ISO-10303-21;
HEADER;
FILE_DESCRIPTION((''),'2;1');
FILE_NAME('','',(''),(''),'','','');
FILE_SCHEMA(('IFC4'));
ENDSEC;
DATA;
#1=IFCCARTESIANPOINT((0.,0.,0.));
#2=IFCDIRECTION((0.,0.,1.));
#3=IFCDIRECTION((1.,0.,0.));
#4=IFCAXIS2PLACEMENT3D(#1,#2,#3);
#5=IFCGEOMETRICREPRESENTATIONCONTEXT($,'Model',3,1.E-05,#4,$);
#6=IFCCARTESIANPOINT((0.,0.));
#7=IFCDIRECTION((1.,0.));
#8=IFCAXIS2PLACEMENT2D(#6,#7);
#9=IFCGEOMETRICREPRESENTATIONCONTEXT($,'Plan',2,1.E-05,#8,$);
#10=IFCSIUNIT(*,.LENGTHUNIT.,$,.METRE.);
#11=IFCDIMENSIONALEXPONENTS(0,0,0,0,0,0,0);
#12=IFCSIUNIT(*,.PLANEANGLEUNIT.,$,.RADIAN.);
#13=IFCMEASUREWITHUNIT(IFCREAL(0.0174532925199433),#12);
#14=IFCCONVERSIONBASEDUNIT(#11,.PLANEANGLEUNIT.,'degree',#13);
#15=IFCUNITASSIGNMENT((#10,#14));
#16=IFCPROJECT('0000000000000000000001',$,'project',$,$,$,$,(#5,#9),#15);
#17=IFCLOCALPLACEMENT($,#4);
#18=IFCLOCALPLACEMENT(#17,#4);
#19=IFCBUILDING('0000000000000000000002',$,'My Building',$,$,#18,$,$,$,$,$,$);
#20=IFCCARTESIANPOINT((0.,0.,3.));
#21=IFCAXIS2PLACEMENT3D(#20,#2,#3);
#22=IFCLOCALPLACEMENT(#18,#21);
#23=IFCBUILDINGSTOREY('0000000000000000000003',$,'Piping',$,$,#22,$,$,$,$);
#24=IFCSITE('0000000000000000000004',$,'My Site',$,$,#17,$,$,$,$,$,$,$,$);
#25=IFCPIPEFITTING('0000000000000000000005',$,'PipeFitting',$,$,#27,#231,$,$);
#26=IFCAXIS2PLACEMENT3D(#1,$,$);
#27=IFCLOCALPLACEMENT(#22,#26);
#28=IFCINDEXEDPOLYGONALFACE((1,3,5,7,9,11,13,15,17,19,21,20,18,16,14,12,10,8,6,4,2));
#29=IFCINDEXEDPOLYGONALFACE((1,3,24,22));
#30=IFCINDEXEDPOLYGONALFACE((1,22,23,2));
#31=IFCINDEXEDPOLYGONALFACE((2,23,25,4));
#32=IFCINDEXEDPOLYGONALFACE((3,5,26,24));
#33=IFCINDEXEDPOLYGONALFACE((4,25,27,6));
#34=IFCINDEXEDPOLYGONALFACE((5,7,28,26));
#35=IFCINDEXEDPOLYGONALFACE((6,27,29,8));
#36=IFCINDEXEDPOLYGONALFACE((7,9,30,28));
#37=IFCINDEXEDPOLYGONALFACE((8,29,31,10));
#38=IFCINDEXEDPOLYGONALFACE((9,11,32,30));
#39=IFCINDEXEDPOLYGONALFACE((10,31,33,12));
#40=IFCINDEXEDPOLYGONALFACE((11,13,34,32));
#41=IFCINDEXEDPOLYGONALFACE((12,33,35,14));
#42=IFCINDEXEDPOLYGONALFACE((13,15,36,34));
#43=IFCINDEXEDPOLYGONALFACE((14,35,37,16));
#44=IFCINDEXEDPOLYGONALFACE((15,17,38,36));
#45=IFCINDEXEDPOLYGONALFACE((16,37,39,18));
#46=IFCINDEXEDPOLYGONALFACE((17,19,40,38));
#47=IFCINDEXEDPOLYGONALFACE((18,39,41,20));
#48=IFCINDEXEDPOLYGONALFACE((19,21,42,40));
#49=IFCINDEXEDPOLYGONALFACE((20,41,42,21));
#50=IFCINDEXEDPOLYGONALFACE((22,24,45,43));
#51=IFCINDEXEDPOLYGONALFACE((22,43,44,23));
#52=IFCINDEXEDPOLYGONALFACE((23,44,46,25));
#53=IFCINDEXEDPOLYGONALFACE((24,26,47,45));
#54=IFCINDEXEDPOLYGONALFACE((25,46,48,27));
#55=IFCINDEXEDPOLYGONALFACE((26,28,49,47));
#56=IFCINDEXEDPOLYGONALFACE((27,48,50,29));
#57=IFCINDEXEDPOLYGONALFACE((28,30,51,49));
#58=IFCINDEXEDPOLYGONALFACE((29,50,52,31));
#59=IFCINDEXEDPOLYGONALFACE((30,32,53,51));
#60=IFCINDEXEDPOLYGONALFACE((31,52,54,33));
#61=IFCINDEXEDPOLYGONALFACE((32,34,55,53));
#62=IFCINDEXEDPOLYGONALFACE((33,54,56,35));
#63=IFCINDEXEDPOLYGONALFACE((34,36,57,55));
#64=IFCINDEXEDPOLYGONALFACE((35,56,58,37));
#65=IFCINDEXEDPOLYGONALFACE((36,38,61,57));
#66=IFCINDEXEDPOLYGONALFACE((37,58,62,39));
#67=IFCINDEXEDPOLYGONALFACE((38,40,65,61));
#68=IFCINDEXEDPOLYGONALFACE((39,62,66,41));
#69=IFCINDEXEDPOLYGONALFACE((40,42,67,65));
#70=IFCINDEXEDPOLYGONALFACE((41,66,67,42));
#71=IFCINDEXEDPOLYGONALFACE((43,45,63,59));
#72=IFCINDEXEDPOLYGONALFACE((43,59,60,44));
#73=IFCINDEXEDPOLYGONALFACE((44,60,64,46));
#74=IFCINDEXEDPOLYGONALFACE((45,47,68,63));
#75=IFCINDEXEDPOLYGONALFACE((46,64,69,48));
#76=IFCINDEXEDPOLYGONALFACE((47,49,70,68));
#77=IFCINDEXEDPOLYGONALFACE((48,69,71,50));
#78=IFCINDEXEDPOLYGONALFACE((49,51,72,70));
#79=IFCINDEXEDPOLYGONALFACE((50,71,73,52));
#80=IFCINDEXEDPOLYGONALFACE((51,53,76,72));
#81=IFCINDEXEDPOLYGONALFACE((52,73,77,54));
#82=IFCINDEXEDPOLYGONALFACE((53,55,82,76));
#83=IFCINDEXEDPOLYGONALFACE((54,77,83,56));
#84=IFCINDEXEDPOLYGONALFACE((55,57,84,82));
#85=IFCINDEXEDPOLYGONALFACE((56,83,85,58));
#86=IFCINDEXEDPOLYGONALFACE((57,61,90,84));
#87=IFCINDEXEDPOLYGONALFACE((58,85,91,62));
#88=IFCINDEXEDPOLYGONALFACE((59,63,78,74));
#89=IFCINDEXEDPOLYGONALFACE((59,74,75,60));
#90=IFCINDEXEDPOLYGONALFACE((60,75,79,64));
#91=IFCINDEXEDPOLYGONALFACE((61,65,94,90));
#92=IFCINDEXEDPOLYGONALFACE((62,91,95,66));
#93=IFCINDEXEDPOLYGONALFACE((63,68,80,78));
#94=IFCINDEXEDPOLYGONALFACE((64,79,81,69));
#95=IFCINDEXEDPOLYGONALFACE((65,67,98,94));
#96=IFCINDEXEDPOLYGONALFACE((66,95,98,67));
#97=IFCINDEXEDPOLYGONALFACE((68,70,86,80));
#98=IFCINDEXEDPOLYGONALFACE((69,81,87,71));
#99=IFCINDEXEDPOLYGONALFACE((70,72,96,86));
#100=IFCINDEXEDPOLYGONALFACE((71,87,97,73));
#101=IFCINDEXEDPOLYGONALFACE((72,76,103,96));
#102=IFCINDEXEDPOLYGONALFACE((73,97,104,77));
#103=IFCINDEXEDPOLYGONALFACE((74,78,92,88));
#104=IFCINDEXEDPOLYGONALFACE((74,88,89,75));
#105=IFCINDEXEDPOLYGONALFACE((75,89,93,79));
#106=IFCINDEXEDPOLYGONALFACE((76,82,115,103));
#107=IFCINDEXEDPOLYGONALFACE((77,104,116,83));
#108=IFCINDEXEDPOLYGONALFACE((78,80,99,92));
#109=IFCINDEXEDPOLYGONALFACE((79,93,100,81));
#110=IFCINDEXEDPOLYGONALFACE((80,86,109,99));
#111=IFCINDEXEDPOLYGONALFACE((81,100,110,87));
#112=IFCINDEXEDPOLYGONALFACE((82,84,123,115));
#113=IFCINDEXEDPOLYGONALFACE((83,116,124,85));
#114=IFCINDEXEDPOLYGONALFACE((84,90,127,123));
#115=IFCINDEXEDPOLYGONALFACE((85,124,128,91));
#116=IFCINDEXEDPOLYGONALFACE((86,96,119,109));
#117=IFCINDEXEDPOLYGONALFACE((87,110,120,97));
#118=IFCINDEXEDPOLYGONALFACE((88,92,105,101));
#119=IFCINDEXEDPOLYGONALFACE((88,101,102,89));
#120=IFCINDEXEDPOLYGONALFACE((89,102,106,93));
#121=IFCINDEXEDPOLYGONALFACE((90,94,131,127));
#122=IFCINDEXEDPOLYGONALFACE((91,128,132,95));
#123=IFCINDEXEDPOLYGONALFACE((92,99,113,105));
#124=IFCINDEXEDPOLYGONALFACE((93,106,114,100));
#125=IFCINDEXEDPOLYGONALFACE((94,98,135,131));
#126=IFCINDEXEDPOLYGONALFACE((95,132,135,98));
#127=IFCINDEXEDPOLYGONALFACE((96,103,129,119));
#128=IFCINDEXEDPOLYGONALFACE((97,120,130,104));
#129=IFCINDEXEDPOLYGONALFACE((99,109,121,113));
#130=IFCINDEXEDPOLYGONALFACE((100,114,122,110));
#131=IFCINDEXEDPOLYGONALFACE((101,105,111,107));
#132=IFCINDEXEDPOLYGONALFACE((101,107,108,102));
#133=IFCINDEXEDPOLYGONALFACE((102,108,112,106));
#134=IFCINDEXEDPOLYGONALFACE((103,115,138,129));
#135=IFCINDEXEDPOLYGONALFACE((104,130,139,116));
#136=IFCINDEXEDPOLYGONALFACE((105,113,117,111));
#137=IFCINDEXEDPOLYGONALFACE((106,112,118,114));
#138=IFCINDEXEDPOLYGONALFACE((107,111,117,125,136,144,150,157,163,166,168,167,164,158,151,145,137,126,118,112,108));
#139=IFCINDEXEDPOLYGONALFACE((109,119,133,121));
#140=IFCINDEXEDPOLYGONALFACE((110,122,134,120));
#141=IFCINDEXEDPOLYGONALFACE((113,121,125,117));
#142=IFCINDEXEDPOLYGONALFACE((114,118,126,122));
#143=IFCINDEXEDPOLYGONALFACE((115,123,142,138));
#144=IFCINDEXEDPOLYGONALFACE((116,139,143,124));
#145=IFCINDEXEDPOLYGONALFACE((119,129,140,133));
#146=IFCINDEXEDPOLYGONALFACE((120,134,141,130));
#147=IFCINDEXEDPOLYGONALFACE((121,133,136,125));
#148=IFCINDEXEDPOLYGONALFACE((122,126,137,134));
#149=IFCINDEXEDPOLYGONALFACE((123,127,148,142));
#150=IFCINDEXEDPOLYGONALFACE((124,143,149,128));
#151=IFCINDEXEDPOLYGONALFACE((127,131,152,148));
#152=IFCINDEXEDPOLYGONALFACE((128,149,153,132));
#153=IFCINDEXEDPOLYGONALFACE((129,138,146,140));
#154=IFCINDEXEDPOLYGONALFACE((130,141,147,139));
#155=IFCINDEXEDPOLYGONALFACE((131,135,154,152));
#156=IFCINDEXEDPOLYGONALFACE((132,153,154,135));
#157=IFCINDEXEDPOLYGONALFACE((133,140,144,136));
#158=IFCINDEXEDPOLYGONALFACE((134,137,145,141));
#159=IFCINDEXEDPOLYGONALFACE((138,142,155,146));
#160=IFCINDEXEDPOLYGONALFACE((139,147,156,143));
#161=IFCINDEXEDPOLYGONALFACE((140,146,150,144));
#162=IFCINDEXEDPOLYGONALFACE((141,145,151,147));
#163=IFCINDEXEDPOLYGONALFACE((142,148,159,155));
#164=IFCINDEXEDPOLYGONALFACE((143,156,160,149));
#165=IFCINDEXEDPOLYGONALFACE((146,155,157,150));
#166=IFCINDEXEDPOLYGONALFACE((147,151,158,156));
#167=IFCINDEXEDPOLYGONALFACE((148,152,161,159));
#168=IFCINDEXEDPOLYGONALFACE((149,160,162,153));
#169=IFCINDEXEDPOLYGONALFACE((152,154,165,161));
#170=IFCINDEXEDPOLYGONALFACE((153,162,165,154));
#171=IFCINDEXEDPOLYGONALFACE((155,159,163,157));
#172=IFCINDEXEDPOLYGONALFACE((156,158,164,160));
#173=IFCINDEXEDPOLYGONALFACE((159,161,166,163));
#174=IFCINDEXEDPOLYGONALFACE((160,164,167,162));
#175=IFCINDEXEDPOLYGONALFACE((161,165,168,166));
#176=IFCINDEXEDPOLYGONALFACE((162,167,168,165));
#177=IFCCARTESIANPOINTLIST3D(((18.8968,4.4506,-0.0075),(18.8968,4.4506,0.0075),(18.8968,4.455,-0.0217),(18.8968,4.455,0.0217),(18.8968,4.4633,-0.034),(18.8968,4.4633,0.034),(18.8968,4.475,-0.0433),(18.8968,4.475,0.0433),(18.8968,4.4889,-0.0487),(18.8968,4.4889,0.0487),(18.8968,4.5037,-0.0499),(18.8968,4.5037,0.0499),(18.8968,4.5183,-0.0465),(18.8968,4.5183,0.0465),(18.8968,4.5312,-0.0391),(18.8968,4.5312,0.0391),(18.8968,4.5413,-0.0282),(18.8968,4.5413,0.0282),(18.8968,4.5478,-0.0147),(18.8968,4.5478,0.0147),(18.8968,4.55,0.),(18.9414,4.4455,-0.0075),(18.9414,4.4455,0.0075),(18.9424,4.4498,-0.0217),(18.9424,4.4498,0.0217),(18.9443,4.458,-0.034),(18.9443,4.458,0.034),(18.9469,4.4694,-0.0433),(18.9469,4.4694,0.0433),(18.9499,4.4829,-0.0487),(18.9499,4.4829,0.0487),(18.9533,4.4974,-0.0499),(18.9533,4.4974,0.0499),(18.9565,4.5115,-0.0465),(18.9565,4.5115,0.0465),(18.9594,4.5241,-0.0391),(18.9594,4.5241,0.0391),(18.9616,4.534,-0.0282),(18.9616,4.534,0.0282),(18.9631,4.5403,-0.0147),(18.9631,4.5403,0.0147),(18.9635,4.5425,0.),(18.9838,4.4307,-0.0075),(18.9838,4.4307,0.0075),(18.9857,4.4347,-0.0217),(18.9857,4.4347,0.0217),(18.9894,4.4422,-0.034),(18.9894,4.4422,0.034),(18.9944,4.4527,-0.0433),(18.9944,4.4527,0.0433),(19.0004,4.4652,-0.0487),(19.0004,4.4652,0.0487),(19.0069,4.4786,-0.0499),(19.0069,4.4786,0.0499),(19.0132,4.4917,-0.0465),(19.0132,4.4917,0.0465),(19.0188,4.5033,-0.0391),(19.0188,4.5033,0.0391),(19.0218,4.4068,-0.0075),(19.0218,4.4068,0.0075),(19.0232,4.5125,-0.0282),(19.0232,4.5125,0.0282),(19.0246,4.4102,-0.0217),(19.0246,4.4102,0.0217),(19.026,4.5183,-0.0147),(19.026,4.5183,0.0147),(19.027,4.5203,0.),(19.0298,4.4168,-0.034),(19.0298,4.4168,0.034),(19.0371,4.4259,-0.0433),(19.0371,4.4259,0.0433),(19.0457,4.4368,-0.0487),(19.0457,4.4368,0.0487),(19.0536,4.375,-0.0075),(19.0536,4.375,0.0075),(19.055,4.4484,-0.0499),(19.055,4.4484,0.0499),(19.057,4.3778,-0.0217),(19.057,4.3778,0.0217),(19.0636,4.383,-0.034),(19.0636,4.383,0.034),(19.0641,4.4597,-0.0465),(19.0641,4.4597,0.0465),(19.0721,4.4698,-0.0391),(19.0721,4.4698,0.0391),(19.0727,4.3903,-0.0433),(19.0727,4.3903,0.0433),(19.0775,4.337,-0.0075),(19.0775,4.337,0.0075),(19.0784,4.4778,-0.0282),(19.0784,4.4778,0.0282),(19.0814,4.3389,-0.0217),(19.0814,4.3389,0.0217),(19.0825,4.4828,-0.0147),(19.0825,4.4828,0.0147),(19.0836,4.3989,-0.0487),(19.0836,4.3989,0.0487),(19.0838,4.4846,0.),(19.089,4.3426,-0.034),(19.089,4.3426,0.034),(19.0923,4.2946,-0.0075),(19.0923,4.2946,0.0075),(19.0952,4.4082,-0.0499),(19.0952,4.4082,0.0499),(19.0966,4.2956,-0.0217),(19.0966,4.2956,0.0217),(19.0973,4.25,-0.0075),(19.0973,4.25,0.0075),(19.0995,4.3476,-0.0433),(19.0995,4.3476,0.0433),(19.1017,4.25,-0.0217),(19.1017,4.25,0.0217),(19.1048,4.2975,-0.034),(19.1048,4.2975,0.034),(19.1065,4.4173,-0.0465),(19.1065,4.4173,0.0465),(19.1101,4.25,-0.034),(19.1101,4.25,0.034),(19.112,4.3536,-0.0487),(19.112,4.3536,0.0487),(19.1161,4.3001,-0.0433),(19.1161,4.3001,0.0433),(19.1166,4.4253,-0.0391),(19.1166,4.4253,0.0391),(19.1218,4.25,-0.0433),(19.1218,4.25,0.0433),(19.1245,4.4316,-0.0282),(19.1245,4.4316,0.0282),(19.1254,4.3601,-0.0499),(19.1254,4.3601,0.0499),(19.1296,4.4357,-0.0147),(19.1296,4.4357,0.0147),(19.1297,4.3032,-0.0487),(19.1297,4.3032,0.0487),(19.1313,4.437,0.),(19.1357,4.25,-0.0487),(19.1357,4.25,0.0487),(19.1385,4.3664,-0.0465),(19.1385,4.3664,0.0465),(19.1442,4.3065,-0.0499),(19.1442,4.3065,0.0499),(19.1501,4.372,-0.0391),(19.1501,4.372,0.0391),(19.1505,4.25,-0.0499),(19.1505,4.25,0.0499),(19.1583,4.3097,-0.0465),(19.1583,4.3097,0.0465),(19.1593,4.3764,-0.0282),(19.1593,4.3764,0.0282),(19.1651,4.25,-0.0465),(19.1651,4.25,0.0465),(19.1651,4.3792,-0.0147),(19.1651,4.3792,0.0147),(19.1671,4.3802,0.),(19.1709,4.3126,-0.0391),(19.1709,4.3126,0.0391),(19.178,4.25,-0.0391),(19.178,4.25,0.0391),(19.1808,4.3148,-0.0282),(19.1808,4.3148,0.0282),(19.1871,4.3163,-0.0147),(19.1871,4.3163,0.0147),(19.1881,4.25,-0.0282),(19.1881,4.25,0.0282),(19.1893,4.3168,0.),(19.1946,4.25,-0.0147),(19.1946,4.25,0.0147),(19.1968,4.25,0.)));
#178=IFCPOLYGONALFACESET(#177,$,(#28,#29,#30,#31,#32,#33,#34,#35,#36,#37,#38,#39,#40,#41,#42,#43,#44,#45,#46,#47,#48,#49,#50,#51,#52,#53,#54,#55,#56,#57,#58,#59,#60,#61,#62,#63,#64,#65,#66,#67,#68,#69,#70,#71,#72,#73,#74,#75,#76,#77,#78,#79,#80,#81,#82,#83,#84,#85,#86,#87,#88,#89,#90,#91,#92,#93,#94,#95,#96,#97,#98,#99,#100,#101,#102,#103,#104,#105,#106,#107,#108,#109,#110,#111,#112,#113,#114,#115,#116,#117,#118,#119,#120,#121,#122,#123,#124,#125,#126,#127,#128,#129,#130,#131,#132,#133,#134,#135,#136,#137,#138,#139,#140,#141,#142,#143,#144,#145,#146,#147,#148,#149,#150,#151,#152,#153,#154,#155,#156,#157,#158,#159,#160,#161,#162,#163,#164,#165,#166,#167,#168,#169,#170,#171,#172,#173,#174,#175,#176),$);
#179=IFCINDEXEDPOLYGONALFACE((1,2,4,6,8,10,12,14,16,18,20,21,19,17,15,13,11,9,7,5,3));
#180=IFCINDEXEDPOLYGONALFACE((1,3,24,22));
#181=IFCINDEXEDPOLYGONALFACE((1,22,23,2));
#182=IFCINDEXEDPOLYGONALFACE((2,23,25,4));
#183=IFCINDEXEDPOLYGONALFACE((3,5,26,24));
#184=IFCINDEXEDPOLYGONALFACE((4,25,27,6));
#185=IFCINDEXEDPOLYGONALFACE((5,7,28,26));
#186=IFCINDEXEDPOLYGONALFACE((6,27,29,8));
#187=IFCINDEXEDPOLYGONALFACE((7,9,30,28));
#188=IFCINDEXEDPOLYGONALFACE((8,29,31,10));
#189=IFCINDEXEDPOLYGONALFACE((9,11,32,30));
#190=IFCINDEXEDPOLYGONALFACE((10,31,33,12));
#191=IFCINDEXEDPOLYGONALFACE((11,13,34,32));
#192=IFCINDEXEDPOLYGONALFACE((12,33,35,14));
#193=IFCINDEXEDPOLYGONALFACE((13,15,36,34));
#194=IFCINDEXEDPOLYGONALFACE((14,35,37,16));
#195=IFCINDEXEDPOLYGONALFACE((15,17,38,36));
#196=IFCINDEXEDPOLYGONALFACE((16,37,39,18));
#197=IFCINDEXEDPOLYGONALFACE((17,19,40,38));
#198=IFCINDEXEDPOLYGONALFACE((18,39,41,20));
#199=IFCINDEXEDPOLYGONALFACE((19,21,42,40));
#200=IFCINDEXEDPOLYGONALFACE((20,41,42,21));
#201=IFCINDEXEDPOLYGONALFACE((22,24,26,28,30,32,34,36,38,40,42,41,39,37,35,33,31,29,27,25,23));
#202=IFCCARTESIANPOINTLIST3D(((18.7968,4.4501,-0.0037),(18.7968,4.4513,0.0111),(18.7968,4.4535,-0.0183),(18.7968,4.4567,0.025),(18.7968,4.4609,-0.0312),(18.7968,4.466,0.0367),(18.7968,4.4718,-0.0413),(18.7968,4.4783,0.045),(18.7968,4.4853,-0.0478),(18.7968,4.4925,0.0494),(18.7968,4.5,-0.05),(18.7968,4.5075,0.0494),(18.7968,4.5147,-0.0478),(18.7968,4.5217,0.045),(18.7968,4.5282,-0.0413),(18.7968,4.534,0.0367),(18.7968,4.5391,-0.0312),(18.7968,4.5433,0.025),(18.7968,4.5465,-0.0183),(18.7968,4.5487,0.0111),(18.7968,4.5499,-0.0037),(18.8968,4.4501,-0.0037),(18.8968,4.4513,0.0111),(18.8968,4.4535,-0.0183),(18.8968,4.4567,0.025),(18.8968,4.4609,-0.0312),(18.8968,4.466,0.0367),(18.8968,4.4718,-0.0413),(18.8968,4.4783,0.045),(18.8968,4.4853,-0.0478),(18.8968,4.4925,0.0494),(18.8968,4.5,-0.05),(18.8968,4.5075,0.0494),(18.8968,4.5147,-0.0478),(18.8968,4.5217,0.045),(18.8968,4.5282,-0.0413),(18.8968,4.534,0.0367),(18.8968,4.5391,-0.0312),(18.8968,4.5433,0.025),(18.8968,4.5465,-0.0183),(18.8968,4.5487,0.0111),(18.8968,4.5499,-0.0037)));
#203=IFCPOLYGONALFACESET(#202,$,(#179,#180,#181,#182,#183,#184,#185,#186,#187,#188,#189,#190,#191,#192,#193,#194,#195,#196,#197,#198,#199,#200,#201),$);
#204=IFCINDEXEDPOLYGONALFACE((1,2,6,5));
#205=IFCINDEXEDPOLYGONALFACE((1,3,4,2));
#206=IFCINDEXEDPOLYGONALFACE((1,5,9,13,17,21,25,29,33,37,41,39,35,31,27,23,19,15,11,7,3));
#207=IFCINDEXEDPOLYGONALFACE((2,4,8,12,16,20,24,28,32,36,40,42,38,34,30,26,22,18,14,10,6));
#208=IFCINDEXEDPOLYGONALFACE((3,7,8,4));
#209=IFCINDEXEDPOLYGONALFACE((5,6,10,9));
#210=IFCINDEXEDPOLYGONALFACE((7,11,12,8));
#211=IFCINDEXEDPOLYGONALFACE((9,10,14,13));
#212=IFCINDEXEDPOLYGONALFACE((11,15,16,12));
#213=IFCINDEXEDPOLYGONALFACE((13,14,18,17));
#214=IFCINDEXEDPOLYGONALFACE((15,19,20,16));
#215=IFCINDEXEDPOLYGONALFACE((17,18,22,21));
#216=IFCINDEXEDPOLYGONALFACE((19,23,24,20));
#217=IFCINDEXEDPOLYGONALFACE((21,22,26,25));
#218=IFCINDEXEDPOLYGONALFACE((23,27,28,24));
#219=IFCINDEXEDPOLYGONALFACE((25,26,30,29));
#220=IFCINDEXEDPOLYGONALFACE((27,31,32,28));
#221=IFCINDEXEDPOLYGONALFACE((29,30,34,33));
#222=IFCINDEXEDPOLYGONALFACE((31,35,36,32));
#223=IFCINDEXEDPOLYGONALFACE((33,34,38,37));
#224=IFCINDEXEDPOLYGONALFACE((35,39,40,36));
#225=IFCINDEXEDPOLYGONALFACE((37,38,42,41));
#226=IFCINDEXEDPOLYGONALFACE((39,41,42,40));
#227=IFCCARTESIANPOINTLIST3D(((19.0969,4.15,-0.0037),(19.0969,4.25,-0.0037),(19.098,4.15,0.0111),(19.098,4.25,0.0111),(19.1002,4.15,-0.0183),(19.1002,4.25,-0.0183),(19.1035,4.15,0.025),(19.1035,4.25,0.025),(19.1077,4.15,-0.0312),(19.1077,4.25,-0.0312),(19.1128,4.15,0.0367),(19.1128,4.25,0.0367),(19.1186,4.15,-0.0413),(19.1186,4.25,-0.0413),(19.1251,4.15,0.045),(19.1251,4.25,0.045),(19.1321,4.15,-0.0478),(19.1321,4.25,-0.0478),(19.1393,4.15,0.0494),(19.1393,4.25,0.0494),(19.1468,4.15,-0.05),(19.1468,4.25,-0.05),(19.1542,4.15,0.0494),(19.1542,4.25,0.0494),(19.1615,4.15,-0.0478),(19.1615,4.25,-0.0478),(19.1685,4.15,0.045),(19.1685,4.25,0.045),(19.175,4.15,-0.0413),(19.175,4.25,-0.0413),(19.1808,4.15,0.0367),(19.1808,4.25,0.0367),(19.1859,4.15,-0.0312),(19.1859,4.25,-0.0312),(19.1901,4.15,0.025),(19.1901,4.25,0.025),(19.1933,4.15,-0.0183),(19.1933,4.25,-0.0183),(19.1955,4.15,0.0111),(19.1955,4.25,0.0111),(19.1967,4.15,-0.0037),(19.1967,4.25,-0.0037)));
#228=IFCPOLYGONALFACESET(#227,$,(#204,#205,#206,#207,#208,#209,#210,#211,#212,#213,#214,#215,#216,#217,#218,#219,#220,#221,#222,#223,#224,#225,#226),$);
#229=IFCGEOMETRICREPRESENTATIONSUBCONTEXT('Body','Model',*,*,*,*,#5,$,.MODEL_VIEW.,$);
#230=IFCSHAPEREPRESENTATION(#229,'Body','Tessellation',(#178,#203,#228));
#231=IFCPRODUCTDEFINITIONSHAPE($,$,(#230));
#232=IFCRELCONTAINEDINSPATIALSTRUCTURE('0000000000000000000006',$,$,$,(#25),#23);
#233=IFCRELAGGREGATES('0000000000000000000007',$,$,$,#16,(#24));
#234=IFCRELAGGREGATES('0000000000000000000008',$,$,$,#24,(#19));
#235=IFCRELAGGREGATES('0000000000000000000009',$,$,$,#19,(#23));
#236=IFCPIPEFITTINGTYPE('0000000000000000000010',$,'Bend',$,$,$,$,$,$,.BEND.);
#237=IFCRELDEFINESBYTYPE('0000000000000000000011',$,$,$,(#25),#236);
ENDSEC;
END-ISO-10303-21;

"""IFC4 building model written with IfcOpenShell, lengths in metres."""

from ifc_helpers import new_model, entity, si_unit, converted_unit, frame, origin_with_axes, origin_2d_with_axis, place, context, subcontext, project, spatial, circle, extrude, source, transform, mapped, type_object, type_shapes, element, save


model = new_model("IFC4")

# Units and contexts
model_context = context("Model", 3, precision=1e-05, world=origin_with_axes())
plan_context = context("Plan", 2, precision=1e-05, world=origin_2d_with_axis())
body_context = subcontext(model_context, "Body", "Model", "MODEL_VIEW")
ifc_project = project(units=[si_unit("LENGTHUNIT", "METRE"), converted_unit("PLANEANGLEUNIT", "degree", entity("IfcReal", 0.0174532925199433), si_unit("PLANEANGLEUNIT", "RADIAN"), dimensions=[0, 0, 0, 0, 0, 0, 0])], contexts=[model_context, plan_context])

# Site, building, storey
site_placement = place(None, origin_with_axes())
site = spatial("IfcSite", under=ifc_project, at=site_placement, Name="My Site")
building_placement = place(site_placement, origin_with_axes())
building = spatial("IfcBuilding", under=site, at=building_placement, Name="My Building")
storey_placement = place(building_placement, frame((0.0, 0.0, 3.0), z_axis=(0.0, 0.0, 1.0), x_axis=(1.0, 0.0, 0.0)))
storey = spatial("IfcBuildingStorey", under=building, at=storey_placement, Name="Piping")

# Pipe fitting
pipe_fitting_type_1 = type_object("IfcPipeFittingType", Name="Bend", PredefinedType="BEND")
shared_shape = source(origin_with_axes(), body_context, "Body", "SolidModel", [
    entity("IfcSweptDiskSolid", entity("IfcIndexedPolyCurve", entity("IfcCartesianPointList3D", [[0.0, 0.0, -0.1], [0.0, 0.0732, -0.2768], [0.0, 0.25, -0.35]]), [entity("IfcArcIndex", [1, 2, 3])]), 0.05),
    extrude(circle(Radius=0.05), origin_with_axes(), (0.0, 0.0, -1.0), 0.1),
    extrude(circle(Radius=0.05), frame((0.0, 0.25, -0.35), z_axis=(0.0, 1.0, 0.0), x_axis=(1.0, 0.0, 0.0)), (0.0, 0.0, 1.0), 0.1),
])
type_shapes(pipe_fitting_type_1, [shared_shape])
for number, where, z_axis, x_axis, name in (
    (1, (18.7968, 4.5, 0.0), (-1.0, 0.0, 0.0), (0.0, 0.0, -1.0), "PipeFitting"),
):
    element("IfcPipeFitting", number, at=place(storey_placement, frame(where, z_axis=z_axis, x_axis=x_axis)), inside=storey, type_object=pipe_fitting_type_1, Name=name, context=body_context, shape_type="MappedRepresentation", body=[
        mapped(shared_shape, transform((0.0, 0.0, 0.0), x_axis=(1.0, 0.0, 0.0), y_axis=(0.0, 1.0, 0.0), z_axis=(0.0, 0.0, 1.0), scale=1.0)),
    ])

save(model, "model.ifc")
